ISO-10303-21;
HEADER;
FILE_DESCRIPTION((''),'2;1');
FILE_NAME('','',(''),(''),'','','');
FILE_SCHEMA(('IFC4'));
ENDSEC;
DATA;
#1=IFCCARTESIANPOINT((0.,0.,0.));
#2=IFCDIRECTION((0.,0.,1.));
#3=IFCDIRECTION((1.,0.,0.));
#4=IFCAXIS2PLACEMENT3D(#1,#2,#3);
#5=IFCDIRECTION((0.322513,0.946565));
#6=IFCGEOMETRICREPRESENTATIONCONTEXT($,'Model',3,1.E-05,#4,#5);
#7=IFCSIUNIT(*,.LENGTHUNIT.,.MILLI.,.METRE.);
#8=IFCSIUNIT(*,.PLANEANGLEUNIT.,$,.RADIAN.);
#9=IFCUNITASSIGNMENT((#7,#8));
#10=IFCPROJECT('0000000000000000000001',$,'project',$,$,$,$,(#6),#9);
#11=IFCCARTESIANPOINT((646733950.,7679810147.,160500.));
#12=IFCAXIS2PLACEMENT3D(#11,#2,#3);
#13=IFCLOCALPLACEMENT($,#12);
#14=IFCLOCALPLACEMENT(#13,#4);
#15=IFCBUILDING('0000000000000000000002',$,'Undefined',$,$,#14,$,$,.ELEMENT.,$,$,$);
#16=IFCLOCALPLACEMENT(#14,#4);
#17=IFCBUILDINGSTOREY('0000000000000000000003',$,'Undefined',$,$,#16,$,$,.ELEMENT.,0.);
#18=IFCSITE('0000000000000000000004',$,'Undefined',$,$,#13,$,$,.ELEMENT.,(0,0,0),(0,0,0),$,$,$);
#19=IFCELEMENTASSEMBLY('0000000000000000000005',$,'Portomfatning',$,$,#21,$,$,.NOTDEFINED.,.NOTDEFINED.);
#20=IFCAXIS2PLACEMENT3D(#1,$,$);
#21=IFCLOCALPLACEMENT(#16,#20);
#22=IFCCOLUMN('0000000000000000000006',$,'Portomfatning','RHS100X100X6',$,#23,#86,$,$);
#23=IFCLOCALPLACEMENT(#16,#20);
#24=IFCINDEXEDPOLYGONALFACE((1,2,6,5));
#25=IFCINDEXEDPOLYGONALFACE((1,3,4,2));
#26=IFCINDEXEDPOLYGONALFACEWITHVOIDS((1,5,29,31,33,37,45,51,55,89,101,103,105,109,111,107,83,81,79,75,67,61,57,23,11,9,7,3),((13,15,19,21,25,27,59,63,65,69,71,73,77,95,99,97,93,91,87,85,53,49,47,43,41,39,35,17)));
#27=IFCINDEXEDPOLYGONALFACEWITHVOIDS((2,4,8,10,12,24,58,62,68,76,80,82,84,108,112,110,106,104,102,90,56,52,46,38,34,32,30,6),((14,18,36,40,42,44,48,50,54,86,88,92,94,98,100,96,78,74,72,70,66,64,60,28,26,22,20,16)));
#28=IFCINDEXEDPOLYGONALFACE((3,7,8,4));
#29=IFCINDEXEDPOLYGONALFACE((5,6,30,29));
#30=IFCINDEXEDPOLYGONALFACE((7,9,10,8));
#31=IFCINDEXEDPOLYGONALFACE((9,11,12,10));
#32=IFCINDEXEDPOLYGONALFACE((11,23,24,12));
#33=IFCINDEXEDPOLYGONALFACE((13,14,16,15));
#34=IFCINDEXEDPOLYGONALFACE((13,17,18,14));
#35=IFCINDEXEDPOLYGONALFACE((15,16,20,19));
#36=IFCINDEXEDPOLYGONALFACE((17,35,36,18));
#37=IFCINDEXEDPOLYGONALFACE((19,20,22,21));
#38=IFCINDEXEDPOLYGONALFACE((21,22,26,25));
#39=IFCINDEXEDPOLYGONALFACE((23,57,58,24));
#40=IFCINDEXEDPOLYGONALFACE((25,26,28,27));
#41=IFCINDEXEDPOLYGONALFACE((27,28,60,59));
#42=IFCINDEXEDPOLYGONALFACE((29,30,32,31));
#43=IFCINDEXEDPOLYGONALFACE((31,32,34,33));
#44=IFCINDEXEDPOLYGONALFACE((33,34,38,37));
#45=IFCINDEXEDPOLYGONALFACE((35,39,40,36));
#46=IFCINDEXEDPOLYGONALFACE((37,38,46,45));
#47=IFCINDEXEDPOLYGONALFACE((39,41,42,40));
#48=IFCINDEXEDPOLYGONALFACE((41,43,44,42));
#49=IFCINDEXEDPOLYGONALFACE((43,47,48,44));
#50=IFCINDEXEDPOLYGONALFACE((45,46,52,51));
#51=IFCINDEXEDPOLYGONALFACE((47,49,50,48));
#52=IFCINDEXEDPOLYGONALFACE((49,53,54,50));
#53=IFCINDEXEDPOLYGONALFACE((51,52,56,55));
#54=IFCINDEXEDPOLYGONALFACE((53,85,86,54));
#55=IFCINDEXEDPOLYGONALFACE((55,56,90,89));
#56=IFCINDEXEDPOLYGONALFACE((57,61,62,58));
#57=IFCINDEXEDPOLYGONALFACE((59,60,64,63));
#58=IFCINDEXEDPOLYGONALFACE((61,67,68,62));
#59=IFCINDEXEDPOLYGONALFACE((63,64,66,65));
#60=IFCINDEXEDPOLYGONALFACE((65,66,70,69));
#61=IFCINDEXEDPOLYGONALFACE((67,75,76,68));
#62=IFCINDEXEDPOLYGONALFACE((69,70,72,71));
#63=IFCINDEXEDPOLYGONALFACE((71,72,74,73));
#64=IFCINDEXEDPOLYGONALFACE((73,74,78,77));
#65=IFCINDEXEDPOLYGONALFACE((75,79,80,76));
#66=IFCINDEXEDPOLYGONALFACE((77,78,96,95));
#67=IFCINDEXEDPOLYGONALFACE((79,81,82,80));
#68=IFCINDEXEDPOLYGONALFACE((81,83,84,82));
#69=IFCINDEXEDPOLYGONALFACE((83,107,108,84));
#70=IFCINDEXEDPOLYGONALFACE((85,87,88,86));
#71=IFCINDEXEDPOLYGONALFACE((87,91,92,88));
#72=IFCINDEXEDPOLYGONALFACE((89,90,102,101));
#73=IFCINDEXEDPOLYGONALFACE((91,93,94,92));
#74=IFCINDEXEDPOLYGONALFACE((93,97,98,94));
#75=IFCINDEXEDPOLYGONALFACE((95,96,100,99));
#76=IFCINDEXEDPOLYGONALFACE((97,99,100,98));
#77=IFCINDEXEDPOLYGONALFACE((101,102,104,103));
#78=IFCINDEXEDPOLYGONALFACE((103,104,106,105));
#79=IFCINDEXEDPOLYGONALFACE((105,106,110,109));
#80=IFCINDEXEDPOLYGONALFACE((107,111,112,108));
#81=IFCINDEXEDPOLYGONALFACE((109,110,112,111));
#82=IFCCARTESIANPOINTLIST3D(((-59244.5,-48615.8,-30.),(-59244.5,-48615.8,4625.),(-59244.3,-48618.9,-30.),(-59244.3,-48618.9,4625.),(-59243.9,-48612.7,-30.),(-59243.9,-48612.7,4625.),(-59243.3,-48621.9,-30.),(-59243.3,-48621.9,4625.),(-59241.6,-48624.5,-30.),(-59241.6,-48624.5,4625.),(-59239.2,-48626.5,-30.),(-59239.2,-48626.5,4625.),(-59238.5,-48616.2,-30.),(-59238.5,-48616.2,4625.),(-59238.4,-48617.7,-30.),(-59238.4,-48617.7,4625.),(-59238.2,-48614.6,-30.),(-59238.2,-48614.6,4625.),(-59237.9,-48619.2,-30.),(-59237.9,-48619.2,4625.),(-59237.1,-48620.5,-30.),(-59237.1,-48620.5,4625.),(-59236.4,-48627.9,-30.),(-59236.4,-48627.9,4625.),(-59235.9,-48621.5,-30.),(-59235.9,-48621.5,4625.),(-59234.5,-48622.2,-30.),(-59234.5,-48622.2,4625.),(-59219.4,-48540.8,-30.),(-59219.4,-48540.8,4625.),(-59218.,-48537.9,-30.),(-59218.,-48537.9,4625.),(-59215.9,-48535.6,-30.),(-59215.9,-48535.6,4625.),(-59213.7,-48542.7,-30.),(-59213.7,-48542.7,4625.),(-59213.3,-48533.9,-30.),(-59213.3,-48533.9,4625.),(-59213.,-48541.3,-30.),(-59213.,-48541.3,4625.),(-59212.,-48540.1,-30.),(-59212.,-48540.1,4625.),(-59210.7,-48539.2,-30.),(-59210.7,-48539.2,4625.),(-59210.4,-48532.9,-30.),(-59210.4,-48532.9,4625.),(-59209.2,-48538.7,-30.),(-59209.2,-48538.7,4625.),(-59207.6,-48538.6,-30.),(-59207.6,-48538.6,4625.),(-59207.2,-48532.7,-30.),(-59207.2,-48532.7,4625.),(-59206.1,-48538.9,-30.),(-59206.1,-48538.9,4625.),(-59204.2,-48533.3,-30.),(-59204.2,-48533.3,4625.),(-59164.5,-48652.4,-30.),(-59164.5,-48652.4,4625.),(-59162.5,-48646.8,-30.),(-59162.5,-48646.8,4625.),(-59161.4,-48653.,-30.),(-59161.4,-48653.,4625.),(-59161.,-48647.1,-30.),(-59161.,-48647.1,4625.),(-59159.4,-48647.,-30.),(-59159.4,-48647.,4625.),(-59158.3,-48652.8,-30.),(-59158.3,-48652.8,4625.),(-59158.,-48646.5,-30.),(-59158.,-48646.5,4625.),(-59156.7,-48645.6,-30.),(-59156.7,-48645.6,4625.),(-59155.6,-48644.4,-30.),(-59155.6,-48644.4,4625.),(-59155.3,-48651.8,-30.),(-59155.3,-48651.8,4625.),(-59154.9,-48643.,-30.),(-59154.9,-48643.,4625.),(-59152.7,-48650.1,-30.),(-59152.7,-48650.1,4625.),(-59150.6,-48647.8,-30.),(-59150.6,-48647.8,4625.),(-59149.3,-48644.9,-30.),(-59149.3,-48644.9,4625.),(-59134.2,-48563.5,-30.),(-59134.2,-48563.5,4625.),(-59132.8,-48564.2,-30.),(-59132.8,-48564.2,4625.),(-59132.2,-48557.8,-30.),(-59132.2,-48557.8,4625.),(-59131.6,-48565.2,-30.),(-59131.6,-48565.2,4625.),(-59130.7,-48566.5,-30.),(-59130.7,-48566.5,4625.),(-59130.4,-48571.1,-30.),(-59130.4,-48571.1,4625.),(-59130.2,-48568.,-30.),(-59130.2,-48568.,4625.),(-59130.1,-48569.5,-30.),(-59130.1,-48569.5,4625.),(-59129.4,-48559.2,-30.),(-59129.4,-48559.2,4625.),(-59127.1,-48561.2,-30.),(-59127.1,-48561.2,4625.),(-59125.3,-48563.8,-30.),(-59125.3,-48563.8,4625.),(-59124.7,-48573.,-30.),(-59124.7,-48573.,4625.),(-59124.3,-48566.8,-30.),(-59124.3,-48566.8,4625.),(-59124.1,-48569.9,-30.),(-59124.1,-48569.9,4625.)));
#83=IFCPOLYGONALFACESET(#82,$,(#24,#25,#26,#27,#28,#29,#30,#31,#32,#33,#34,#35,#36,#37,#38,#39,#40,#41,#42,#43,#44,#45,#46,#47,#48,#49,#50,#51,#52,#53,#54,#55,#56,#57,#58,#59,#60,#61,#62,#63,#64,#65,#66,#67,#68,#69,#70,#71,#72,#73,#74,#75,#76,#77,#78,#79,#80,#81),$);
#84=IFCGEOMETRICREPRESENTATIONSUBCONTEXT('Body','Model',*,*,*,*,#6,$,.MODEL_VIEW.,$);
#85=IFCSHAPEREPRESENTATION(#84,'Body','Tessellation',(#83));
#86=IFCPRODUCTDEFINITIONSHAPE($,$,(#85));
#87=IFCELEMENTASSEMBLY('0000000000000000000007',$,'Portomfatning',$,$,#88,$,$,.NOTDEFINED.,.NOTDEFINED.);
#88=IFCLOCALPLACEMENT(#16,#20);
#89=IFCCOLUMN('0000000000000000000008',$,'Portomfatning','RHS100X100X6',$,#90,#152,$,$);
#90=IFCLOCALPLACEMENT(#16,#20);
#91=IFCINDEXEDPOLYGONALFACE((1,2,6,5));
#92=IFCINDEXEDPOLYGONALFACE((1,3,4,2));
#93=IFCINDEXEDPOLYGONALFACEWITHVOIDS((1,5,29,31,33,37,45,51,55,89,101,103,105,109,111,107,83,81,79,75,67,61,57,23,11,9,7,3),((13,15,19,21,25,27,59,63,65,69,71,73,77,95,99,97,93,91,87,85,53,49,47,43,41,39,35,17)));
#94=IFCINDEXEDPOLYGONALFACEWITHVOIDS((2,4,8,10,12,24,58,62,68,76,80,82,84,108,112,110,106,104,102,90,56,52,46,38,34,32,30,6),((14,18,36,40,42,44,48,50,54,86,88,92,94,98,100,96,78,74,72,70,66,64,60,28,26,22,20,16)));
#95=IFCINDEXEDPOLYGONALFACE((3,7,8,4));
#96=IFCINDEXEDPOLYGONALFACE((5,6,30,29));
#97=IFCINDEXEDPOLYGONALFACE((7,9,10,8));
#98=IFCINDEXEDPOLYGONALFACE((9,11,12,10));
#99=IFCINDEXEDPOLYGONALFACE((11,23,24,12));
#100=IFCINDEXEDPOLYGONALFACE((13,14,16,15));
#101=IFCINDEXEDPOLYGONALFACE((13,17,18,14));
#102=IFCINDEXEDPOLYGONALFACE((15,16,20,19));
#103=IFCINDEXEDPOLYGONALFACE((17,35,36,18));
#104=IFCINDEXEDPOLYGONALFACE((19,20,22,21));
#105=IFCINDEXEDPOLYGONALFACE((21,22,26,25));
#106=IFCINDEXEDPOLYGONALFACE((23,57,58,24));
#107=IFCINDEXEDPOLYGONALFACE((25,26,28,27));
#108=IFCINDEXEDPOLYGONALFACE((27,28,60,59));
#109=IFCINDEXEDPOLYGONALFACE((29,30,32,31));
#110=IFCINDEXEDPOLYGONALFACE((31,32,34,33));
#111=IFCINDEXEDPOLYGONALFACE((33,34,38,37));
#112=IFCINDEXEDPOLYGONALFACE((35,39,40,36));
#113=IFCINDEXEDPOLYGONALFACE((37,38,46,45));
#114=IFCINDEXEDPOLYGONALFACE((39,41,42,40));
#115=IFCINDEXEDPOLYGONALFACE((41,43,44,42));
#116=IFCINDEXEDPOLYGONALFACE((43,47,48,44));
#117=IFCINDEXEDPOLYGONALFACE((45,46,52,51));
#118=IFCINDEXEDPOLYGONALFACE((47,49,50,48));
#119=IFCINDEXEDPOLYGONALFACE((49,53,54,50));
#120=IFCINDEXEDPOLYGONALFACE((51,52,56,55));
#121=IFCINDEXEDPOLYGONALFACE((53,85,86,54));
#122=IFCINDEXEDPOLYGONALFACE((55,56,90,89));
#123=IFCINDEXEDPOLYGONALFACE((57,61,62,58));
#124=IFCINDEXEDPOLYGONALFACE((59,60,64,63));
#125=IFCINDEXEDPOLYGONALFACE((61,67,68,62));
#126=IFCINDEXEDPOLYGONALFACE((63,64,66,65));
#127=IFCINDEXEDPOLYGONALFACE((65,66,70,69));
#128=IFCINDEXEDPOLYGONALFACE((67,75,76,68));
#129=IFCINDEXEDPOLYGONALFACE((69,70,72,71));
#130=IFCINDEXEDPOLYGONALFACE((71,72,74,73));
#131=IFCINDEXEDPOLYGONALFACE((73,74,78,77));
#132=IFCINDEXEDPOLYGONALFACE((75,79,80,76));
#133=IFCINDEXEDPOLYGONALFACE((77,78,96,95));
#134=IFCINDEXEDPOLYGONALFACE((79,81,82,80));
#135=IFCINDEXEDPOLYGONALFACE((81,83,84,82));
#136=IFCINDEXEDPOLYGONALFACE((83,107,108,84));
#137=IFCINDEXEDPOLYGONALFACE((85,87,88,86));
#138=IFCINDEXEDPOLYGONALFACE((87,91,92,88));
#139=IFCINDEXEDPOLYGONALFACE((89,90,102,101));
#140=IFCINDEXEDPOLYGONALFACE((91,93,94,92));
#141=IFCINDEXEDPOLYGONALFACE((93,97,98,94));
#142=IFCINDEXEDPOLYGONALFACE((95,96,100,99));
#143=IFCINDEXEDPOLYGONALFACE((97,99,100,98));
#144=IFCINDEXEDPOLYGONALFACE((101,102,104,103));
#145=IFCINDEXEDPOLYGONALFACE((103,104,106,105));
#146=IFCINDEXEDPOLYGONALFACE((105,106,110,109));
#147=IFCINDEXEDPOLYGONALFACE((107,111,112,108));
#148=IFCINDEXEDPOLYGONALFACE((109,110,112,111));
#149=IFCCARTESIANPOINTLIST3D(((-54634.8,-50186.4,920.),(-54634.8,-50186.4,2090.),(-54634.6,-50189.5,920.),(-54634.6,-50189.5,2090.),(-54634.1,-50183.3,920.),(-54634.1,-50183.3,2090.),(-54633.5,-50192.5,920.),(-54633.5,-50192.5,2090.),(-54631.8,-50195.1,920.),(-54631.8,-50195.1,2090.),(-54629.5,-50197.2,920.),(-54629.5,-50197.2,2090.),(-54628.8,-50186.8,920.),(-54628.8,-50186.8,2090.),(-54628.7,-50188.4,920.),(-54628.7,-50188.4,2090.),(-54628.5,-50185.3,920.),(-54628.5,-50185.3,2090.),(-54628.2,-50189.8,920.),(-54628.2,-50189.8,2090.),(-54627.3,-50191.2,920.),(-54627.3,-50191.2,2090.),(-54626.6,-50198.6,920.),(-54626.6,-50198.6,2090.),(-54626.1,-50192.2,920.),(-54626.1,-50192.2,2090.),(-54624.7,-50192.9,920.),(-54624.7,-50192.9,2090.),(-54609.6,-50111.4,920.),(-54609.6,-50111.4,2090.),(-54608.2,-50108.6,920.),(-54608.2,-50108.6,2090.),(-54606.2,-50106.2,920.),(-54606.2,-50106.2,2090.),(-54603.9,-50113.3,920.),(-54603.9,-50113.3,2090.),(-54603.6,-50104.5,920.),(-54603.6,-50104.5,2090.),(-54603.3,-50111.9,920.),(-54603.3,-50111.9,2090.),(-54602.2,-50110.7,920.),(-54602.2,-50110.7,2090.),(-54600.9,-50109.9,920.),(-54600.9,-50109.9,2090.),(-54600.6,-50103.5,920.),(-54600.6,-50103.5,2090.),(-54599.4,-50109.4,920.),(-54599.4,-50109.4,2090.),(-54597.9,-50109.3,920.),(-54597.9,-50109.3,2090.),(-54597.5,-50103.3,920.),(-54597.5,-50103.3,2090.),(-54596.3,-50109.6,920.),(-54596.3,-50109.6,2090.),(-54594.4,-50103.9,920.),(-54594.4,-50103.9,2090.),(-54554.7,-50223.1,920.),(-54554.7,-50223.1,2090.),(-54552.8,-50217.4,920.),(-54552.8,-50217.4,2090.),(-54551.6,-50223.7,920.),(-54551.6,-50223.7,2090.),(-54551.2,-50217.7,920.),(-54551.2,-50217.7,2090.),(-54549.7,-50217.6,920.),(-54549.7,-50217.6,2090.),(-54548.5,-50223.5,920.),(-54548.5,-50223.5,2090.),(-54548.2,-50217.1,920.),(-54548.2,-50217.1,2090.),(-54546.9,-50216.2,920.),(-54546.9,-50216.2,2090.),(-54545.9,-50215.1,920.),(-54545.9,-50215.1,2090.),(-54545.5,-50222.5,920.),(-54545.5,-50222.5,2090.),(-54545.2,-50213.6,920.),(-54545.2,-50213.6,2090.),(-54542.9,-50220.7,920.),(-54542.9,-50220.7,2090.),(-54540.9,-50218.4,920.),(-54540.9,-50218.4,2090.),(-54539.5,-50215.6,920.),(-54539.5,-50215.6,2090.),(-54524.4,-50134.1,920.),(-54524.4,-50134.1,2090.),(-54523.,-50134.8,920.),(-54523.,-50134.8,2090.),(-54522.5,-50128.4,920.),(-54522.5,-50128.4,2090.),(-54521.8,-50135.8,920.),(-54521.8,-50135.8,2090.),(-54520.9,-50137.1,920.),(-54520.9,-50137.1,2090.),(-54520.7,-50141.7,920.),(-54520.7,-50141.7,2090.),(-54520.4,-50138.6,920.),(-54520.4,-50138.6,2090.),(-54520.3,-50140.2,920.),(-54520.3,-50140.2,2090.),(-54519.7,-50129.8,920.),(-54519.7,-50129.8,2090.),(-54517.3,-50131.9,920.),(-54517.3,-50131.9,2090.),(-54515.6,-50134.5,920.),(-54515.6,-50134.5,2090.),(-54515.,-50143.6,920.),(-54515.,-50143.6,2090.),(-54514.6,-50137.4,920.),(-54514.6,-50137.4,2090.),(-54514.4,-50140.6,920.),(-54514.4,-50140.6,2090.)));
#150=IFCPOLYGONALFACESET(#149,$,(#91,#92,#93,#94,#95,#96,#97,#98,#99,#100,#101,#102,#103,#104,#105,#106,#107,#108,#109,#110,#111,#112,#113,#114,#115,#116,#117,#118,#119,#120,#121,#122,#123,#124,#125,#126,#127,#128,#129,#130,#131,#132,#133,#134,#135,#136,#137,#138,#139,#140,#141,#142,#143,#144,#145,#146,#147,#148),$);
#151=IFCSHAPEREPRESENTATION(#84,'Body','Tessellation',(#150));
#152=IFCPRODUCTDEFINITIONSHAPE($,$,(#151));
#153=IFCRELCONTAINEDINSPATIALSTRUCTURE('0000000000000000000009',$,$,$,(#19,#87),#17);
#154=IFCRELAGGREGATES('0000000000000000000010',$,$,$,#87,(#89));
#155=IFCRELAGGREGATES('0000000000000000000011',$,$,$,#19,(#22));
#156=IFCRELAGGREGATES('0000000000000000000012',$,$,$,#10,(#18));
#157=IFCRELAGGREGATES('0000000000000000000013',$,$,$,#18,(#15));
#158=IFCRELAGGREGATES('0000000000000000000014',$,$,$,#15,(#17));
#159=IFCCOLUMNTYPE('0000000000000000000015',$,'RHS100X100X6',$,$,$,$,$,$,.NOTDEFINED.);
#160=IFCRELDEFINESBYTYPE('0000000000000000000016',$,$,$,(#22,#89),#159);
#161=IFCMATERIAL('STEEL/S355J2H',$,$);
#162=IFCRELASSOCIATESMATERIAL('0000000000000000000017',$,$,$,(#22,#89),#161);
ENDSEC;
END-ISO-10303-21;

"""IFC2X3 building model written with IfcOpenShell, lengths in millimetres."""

from ifc_helpers import new_model, si_unit, direction, frame, origin_with_axes, origin_2d_with_axis, place, context, subcontext, project, spatial, hollow_rectangle, extrude, clip, halfspace, material, type_object, element, aggregate, save


model = new_model("IFC2X3")

# Units and contexts
model_context = context("Model", 3, precision=1e-05, world=origin_with_axes(), true_north=direction((0.322513, 0.946565)))
body_context = subcontext(model_context, "Body", "Model", "MODEL_VIEW")
ifc_project = project(units=[si_unit("LENGTHUNIT", "METRE", prefix="MILLI"), si_unit("PLANEANGLEUNIT", "RADIAN")], contexts=[model_context])

# Site, building, storey
site_placement = place(None, frame((646733950.0, 7679810147.0, 160500.0), z_axis=(0.0, 0.0, 1.0), x_axis=(1.0, 0.0, 0.0)))
site = spatial("IfcSite", under=ifc_project, at=site_placement, Name="Undefined", CompositionType="ELEMENT", RefLatitude=(0, 0, 0), RefLongitude=(0, 0, 0))
building_placement = place(site_placement, origin_with_axes())
building = spatial("IfcBuilding", under=site, at=building_placement, Name="Undefined", CompositionType="ELEMENT")
storey_placement = place(building_placement, origin_with_axes())
storey = spatial("IfcBuildingStorey", under=building, at=storey_placement, Name="Undefined", CompositionType="ELEMENT", Elevation=0.0)

# Element assemblies, columns
assembly_1_placement = place(storey_placement, origin_with_axes())
assembly_1 = element("IfcElementAssembly", 1, at=assembly_1_placement, inside=storey, Name="Portomfatning", AssemblyPlace="NOTDEFINED", PredefinedType="NOTDEFINED")
ifc_material_1 = material(Name="STEEL/S355J2H")
column_type_1 = type_object("IfcColumnType", Name="RHS100X100X6", PredefinedType="NOTDEFINED")
column_1_placement = place(assembly_1_placement, frame((-59184.3, -48592.8, -30.0), z_axis=(0.0, 0.0, 1.0), x_axis=(-0.946565, 0.322513, 0.0)))
column_1 = element("IfcColumn", 2, at=column_1_placement, type_object=column_type_1, material=ifc_material_1, Name="Portomfatning", Description="RHS100X100X6", context=body_context, shape_type="SweptSolid", body=[
    extrude(hollow_rectangle(XDim=100.0, YDim=100.0, WallThickness=6.0, InnerFilletRadius=6.0, OuterFilletRadius=12.0, at=origin_2d_with_axis()), frame((0.0, 0.0, 4655.0), z_axis=(0.0, 0.0, -1.0), x_axis=(0.0, 1.0, 0.0)), (0.0, 0.0, 1.0), 4655.0),
])
assembly_2_placement = place(storey_placement, origin_with_axes())
assembly_2 = element("IfcElementAssembly", 3, at=assembly_2_placement, inside=storey, Name="Portomfatning", AssemblyPlace="NOTDEFINED", PredefinedType="NOTDEFINED")
column_2_placement = place(assembly_2_placement, frame((-54574.6, -50163.5, 910.0), z_axis=(0.0, 0.0, 1.0), x_axis=(-0.946565, 0.322513, 0.0)))
column_2 = element("IfcColumn", 4, at=column_2_placement, type_object=column_type_1, material=ifc_material_1, Name="Portomfatning", Description="RHS100X100X6", context=body_context, shape_type="Clipping", body=[
    clip(clip(extrude(hollow_rectangle(XDim=100.0, YDim=100.0, WallThickness=6.0, InnerFilletRadius=6.0, OuterFilletRadius=12.0, at=origin_2d_with_axis()), frame((0.0, 0.0, 1190.0), z_axis=(0.0, 0.0, -1.0), x_axis=(0.0, 1.0, 0.0)), (0.0, 0.0, 1.0), 1190.0), halfspace(frame((50.0, 0.0, 1180.0), z_axis=(0.0, 0.0, -1.0), x_axis=(0.0, 1.0, 0.0)), True)), halfspace(frame((50.0, 0.0, 10.0), z_axis=(0.0, 0.0, 1.0), x_axis=(0.0, -1.0, 0.0)), True)),
])

aggregate(assembly_2, [column_2])
aggregate(assembly_1, [column_1])

save(model, "model.ifc")
